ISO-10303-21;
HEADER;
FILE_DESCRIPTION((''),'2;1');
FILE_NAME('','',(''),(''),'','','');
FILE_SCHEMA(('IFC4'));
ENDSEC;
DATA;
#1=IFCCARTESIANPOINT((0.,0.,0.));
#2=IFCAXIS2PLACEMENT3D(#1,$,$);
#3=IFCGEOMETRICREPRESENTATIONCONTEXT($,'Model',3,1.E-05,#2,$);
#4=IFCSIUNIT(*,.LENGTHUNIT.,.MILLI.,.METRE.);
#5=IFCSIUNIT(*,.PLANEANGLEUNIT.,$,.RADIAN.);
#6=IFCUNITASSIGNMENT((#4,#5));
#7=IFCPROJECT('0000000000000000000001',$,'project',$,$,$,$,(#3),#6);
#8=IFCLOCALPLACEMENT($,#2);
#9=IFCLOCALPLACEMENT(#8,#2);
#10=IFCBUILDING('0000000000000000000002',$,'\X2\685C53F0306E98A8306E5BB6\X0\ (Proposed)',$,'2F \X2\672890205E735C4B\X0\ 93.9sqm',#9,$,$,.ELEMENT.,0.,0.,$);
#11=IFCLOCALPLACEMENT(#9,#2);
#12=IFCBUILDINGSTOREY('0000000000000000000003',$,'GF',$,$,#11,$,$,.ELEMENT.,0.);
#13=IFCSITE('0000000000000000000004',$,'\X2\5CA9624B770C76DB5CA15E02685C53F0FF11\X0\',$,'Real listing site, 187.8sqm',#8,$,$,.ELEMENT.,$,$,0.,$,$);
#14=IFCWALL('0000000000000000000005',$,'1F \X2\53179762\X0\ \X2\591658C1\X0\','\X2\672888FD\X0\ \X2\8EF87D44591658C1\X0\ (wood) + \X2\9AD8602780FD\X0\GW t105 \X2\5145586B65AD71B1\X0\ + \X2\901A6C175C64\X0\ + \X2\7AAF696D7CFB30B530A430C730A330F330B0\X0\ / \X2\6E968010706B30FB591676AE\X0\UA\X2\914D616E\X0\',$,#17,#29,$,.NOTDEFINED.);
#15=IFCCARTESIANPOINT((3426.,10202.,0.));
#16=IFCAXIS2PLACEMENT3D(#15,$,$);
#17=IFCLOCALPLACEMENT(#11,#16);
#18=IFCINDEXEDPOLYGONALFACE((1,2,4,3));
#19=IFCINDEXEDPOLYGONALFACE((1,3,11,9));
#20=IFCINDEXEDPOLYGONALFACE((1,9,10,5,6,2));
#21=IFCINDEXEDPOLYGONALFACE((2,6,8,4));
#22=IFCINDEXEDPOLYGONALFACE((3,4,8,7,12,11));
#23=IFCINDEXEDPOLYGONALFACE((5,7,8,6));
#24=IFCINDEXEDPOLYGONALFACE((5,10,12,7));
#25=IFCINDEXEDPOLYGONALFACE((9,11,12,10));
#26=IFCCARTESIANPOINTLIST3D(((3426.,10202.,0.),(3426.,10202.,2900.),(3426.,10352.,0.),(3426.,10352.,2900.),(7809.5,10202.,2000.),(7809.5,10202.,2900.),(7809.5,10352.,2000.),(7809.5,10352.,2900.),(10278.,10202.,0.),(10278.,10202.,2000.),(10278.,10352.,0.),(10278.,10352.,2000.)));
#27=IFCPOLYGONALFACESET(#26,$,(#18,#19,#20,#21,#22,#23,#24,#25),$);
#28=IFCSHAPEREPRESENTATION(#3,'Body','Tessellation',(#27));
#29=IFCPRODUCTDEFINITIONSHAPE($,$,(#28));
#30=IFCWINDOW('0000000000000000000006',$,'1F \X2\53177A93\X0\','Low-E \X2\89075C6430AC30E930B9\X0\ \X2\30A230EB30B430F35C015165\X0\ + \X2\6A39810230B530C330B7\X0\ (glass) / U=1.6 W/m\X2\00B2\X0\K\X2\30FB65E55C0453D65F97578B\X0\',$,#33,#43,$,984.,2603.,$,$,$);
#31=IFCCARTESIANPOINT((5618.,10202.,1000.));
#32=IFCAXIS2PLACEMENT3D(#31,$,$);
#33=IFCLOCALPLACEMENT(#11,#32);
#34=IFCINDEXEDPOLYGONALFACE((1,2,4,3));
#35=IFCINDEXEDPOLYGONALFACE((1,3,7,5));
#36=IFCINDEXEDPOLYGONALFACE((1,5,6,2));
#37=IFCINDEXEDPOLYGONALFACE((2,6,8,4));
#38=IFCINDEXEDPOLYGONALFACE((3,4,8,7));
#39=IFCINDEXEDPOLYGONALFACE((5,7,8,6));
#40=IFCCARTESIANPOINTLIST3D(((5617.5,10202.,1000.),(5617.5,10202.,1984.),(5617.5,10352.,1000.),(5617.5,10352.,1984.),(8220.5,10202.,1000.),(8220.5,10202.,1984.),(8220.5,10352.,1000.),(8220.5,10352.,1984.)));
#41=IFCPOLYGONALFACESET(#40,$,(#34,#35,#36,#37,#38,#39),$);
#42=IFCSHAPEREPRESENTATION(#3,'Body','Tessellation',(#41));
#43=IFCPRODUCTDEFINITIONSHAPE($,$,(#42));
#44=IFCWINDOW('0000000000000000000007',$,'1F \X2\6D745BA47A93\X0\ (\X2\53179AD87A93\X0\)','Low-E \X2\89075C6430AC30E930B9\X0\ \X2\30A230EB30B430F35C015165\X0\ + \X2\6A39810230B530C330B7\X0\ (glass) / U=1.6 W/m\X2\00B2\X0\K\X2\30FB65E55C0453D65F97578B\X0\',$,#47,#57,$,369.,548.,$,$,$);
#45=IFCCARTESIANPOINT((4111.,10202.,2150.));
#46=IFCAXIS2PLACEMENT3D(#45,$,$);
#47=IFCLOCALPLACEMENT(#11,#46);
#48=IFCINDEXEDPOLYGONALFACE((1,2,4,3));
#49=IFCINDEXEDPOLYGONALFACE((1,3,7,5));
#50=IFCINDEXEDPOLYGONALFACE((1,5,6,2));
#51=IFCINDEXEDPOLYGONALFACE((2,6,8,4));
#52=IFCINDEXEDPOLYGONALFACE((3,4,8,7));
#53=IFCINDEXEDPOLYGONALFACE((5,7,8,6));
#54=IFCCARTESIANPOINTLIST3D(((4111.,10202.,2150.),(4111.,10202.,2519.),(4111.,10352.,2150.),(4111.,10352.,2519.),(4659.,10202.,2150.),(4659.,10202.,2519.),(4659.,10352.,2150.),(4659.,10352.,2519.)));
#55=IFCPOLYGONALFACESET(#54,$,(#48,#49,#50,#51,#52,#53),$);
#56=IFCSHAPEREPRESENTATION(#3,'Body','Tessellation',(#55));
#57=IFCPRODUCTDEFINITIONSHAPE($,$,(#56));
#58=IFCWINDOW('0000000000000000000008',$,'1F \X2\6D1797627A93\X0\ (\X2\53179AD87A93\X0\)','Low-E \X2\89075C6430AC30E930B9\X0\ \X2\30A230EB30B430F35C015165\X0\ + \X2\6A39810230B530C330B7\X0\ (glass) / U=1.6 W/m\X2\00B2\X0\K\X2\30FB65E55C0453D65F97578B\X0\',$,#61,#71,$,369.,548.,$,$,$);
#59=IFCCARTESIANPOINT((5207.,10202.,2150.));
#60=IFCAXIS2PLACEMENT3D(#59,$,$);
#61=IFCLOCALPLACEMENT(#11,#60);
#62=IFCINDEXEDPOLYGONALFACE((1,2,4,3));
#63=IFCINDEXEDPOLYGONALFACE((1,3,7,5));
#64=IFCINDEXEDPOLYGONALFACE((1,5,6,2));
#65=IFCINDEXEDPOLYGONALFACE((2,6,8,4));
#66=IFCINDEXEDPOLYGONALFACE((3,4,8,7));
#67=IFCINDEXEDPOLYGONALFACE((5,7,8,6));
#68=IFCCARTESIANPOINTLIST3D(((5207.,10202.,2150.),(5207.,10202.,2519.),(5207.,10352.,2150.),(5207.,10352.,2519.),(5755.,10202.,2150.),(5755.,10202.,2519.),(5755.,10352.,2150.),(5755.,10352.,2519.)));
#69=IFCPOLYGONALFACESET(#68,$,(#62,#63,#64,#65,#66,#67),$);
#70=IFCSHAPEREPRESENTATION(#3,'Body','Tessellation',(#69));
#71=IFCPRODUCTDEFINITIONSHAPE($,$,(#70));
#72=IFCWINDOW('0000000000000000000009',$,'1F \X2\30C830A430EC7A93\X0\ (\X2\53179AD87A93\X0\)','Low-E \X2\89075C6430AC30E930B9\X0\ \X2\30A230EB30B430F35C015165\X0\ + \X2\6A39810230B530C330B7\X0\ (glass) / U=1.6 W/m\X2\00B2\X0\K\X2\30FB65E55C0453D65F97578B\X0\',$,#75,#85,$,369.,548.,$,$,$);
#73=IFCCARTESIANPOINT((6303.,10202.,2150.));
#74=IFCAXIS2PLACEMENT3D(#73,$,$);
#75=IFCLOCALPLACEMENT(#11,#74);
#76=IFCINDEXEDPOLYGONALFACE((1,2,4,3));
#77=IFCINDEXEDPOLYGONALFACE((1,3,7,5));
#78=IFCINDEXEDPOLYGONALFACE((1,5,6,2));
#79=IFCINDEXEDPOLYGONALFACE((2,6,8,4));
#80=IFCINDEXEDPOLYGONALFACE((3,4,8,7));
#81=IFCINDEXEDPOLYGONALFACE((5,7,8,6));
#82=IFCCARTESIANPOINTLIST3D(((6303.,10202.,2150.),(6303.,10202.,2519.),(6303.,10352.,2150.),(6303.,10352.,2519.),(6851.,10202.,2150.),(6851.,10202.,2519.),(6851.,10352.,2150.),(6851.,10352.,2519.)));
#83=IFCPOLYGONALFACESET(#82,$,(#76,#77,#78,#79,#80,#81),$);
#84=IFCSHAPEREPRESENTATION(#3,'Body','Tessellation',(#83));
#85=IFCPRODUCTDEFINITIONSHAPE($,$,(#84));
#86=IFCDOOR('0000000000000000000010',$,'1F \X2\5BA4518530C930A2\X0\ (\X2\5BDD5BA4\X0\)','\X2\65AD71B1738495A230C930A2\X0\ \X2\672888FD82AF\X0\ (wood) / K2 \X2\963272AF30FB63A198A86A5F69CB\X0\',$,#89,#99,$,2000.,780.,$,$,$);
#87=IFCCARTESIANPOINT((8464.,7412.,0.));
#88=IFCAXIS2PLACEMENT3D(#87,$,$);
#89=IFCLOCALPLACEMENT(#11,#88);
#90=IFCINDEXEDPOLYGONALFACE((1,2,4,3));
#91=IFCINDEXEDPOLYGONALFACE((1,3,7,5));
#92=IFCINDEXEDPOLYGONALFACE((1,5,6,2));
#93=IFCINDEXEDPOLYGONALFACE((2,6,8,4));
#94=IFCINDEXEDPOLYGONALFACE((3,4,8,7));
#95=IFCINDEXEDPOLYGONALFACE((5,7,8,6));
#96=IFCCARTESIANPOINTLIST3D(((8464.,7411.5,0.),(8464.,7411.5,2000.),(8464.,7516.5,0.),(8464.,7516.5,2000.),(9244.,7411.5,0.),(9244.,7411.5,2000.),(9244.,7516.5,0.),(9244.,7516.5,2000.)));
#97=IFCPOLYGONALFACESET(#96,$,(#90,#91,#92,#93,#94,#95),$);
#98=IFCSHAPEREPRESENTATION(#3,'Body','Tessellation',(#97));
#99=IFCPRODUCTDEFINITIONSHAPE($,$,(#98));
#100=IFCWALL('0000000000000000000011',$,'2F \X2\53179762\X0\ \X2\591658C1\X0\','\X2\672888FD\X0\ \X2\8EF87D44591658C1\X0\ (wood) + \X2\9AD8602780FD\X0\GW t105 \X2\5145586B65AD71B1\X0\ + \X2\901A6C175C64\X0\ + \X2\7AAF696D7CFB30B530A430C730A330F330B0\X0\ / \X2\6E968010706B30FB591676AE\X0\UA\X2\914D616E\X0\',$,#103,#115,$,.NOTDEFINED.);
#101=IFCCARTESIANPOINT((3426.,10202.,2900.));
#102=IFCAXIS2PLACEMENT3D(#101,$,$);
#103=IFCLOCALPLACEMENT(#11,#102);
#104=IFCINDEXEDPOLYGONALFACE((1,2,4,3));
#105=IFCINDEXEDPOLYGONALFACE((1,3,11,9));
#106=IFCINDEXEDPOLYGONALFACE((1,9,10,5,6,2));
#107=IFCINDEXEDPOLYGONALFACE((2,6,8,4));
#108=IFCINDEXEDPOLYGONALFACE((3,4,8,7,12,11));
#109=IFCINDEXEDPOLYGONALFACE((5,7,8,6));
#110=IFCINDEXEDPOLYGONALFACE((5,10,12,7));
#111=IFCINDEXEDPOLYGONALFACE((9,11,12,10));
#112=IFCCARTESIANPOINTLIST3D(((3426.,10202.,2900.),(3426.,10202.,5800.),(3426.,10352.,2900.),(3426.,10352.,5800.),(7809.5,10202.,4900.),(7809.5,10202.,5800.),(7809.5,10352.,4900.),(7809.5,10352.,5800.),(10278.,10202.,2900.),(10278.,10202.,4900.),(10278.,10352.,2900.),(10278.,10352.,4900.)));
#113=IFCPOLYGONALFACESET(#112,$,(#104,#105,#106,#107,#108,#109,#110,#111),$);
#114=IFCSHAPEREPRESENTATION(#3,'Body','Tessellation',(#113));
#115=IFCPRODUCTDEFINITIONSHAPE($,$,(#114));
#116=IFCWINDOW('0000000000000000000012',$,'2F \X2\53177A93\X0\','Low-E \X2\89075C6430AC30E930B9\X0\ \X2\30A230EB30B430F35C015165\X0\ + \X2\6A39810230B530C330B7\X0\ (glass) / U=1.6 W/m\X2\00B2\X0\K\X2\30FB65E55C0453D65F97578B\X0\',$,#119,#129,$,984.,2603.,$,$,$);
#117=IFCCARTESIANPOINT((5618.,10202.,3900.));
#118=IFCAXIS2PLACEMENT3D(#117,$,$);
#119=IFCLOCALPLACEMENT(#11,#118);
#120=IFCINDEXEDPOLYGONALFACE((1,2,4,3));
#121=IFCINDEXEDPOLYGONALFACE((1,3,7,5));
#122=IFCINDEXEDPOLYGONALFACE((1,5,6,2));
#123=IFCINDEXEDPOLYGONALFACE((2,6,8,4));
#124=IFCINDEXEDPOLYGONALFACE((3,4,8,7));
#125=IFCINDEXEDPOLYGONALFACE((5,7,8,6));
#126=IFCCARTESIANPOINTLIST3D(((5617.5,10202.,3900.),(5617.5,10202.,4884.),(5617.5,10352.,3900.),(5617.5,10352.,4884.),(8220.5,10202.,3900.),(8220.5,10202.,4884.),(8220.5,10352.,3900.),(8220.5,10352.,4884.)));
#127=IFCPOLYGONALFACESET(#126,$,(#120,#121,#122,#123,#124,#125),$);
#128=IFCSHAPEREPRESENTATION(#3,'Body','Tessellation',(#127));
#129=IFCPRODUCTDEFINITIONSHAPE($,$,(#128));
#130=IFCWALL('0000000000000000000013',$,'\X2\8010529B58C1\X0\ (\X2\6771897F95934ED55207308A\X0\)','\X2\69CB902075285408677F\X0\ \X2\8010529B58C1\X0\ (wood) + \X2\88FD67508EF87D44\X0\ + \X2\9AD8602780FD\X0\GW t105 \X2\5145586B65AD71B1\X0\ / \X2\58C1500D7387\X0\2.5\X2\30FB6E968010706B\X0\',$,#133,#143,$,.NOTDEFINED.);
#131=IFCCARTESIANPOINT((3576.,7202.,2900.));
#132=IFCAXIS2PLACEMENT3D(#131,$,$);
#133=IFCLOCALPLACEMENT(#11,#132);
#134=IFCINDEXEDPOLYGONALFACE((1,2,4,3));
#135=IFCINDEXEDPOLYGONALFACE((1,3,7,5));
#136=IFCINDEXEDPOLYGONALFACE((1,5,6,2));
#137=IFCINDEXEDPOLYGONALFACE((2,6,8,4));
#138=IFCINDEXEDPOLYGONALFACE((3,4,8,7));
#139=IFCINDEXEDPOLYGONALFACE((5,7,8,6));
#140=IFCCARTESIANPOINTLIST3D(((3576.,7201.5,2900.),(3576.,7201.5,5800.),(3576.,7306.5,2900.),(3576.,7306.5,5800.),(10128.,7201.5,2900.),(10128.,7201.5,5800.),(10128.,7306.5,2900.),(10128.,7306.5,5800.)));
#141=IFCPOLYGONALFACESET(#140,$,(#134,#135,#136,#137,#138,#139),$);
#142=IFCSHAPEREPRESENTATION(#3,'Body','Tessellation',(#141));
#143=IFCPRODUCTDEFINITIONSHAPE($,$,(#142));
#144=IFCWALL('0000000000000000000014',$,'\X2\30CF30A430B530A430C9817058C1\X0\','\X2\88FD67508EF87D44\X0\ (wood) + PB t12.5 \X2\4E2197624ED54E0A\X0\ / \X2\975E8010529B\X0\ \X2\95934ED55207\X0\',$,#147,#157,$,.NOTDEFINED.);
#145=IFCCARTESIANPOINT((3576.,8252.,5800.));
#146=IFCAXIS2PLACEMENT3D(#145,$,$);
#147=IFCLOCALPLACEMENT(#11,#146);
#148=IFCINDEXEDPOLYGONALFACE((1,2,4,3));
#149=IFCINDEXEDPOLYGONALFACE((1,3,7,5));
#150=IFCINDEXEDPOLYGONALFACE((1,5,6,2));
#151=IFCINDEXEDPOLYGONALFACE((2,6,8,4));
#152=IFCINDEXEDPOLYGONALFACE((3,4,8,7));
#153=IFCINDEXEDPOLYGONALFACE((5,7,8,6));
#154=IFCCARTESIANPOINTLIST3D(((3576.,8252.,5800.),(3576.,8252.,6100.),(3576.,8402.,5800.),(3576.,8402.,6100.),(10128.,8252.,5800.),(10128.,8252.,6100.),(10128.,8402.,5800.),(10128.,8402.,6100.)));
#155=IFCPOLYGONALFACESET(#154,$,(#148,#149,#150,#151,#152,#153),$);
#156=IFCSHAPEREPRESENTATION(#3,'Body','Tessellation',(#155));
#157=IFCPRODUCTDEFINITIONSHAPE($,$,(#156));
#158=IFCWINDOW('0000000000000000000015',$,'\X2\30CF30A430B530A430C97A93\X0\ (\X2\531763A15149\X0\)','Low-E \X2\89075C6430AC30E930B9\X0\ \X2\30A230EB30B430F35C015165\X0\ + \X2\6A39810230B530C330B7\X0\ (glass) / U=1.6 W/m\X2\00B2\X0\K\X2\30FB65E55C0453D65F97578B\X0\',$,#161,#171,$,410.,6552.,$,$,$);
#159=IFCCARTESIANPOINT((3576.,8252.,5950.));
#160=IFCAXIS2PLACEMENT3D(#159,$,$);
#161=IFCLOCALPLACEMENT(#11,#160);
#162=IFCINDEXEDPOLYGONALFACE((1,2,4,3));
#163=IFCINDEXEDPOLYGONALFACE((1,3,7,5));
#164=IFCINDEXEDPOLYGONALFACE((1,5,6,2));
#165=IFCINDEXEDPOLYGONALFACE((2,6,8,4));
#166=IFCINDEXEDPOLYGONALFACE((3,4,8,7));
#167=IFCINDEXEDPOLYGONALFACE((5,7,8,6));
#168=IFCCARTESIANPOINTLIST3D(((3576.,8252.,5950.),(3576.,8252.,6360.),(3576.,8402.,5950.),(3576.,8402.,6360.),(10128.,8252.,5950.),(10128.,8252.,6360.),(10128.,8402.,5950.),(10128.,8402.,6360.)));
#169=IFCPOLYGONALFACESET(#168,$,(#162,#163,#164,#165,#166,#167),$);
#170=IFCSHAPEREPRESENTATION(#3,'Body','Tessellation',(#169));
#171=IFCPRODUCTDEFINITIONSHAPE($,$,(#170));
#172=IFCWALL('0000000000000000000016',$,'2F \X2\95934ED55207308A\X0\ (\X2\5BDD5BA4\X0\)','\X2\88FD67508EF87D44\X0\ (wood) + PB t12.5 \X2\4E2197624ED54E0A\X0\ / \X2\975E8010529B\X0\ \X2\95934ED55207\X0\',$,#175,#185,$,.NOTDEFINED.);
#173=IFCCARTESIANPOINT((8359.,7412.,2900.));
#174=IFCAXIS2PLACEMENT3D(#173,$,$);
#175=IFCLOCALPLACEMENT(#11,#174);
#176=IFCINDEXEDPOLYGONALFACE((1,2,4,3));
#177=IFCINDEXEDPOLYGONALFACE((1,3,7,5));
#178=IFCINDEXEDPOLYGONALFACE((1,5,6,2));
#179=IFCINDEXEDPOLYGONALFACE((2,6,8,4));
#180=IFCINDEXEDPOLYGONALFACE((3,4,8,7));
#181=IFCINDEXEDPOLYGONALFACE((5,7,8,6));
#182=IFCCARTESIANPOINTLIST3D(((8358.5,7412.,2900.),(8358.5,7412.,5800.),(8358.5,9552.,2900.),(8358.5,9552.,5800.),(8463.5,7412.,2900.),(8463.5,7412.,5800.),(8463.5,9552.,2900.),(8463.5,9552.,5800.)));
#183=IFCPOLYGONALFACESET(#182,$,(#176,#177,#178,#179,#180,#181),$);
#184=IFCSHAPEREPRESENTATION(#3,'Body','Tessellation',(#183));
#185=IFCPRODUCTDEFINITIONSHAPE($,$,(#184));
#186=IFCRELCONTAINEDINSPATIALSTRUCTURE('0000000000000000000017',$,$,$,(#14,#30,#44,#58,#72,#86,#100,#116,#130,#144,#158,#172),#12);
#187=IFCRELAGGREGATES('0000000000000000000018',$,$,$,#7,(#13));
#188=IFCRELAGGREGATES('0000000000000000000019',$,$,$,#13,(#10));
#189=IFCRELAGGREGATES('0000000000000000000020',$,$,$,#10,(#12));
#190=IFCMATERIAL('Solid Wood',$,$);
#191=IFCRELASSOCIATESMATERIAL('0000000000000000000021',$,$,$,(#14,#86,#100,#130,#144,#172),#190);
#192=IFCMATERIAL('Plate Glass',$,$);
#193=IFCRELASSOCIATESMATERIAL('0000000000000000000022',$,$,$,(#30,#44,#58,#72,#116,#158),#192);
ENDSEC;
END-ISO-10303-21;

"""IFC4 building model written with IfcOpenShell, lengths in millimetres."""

from ifc_helpers import new_model, si_unit, frame, frame_2d, origin, place, context, project, spatial, rectangle, extrude, material, element, fill, save


model = new_model("IFC4")

# Units and contexts
model_context = context("Model", 3, precision=1e-05, world=origin())
ifc_project = project(units=[si_unit("LENGTHUNIT", "METRE", prefix="MILLI"), si_unit("PLANEANGLEUNIT", "RADIAN")], contexts=[model_context])

# Site, building, storey
site_placement = place(None, origin())
site = spatial("IfcSite", under=ifc_project, at=site_placement, Name="岩手県盛岡市桜台１", ObjectType="Real listing site, 187.8sqm", CompositionType="ELEMENT", RefElevation=0.0)
building_placement = place(site_placement, origin())
building = spatial("IfcBuilding", under=site, at=building_placement, Name="桜台の風の家 (Proposed)", ObjectType="2F 木造平屋 93.9sqm", CompositionType="ELEMENT", ElevationOfRefHeight=0.0, ElevationOfTerrain=0.0)
storey_placement = place(building_placement, origin())
storey = spatial("IfcBuildingStorey", under=building, at=storey_placement, Name="GF", CompositionType="ELEMENT", Elevation=0.0)

# Wall, openings, windows
ifc_material_1 = material(Name="Solid Wood")
wall_1_placement = place(storey_placement, frame((3426.0, 10202.0, 0.0)))
wall_1 = element("IfcWall", 1, at=wall_1_placement, inside=storey, material=ifc_material_1, Name="1F 北面 外壁", Description="木製 軸組外壁 (wood) + 高性能GW t105 充填断熱 + 通気層 + 窯業系サイディング / 準耐火・外皮UA配慮", PredefinedType="NOTDEFINED", context=model_context, shape_type="SweptSolid", body=[
    extrude(rectangle(XDim=6852.0, YDim=150.0, at=frame_2d((3426.0, 75.0))), frame((3426.0, 10202.0, 0.0)), (0.0, 0.0, 1.0), 2900.0),
])
opening_1_placement = place(storey_placement, frame((5618.0, 10202.0, 1000.0)))
opening_1 = element("IfcOpeningElement", 2, at=opening_1_placement, cuts=wall_1, PredefinedType="NOTDEFINED", context=model_context, shape_type="SweptSolid", body=[
    extrude(rectangle(XDim=2603.0, YDim=150.0, at=frame_2d((1301.0, 75.0))), frame((5618.0, 10202.0, 1000.0)), (0.0, 0.0, 1.0), 984.0),
])
opening_2_placement = place(storey_placement, frame((4111.0, 10202.0, 2150.0)))
opening_2 = element("IfcOpeningElement", 3, at=opening_2_placement, cuts=wall_1, PredefinedType="NOTDEFINED", context=model_context, shape_type="SweptSolid", body=[
    extrude(rectangle(XDim=548.0, YDim=150.0, at=frame_2d((274.0, 75.0))), frame((4111.0, 10202.0, 2150.0)), (0.0, 0.0, 1.0), 369.0),
])
opening_3_placement = place(storey_placement, frame((5207.0, 10202.0, 2150.0)))
opening_3 = element("IfcOpeningElement", 4, at=opening_3_placement, cuts=wall_1, PredefinedType="NOTDEFINED", context=model_context, shape_type="SweptSolid", body=[
    extrude(rectangle(XDim=548.0, YDim=150.0, at=frame_2d((274.0, 75.0))), frame((5207.0, 10202.0, 2150.0)), (0.0, 0.0, 1.0), 369.0),
])
opening_4_placement = place(storey_placement, frame((6303.0, 10202.0, 2150.0)))
opening_4 = element("IfcOpeningElement", 5, at=opening_4_placement, cuts=wall_1, PredefinedType="NOTDEFINED", context=model_context, shape_type="SweptSolid", body=[
    extrude(rectangle(XDim=548.0, YDim=150.0, at=frame_2d((274.0, 75.0))), frame((6303.0, 10202.0, 2150.0)), (0.0, 0.0, 1.0), 369.0),
])
ifc_material_2 = material(Name="Plate Glass")
window_1_placement = place(storey_placement, frame((5618.0, 10202.0, 1000.0)))
window_1 = element("IfcWindow", 6, at=window_1_placement, inside=storey, material=ifc_material_2, Name="1F 北窓", Description="Low-E 複層ガラス アルゴン封入 + 樹脂サッシ (glass) / U=1.6 W/m²K・日射取得型", OverallHeight=984.0, OverallWidth=2603.0, context=model_context, shape_type="SweptSolid", body=[
    extrude(rectangle(XDim=2603.0, YDim=150.0, at=frame_2d((1301.0, 75.0))), frame((5618.0, 10202.0, 1000.0)), (0.0, 0.0, 1.0), 984.0),
])
fill(opening_1, window_1)
window_2_placement = place(storey_placement, frame((4111.0, 10202.0, 2150.0)))
window_2 = element("IfcWindow", 7, at=window_2_placement, inside=storey, material=ifc_material_2, Name="1F 浴室窓 (北高窓)", Description="Low-E 複層ガラス アルゴン封入 + 樹脂サッシ (glass) / U=1.6 W/m²K・日射取得型", OverallHeight=369.0, OverallWidth=548.0, context=model_context, shape_type="SweptSolid", body=[
    extrude(rectangle(XDim=548.0, YDim=150.0, at=frame_2d((274.0, 75.0))), frame((4111.0, 10202.0, 2150.0)), (0.0, 0.0, 1.0), 369.0),
])
fill(opening_2, window_2)
window_3_placement = place(storey_placement, frame((5207.0, 10202.0, 2150.0)))
window_3 = element("IfcWindow", 8, at=window_3_placement, inside=storey, material=ifc_material_2, Name="1F 洗面窓 (北高窓)", Description="Low-E 複層ガラス アルゴン封入 + 樹脂サッシ (glass) / U=1.6 W/m²K・日射取得型", OverallHeight=369.0, OverallWidth=548.0, context=model_context, shape_type="SweptSolid", body=[
    extrude(rectangle(XDim=548.0, YDim=150.0, at=frame_2d((274.0, 75.0))), frame((5207.0, 10202.0, 2150.0)), (0.0, 0.0, 1.0), 369.0),
])
fill(opening_3, window_3)
window_4_placement = place(storey_placement, frame((6303.0, 10202.0, 2150.0)))
window_4 = element("IfcWindow", 9, at=window_4_placement, inside=storey, material=ifc_material_2, Name="1F トイレ窓 (北高窓)", Description="Low-E 複層ガラス アルゴン封入 + 樹脂サッシ (glass) / U=1.6 W/m²K・日射取得型", OverallHeight=369.0, OverallWidth=548.0, context=model_context, shape_type="SweptSolid", body=[
    extrude(rectangle(XDim=548.0, YDim=150.0, at=frame_2d((274.0, 75.0))), frame((6303.0, 10202.0, 2150.0)), (0.0, 0.0, 1.0), 369.0),
])
fill(opening_4, window_4)

# Door
door_1_placement = place(storey_placement, frame((8464.0, 7412.0, 0.0)))
element("IfcDoor", 10, at=door_1_placement, inside=storey, material=ifc_material_1, Name="1F 室内ドア (寝室)", Description="断熱玄関ドア 木製芯 (wood) / K2 防犯・採風機構", OverallHeight=2000.0, OverallWidth=780.0, context=model_context, shape_type="SweptSolid", body=[
    extrude(rectangle(XDim=780.0, YDim=105.0, at=frame_2d((390.0, 52.0))), frame((8464.0, 7412.0, 0.0)), (0.0, 0.0, 1.0), 2000.0),
])

# Wall, opening, window
wall_2_placement = place(storey_placement, frame((3426.0, 10202.0, 2900.0)))
wall_2 = element("IfcWall", 11, at=wall_2_placement, inside=storey, material=ifc_material_1, Name="2F 北面 外壁", Description="木製 軸組外壁 (wood) + 高性能GW t105 充填断熱 + 通気層 + 窯業系サイディング / 準耐火・外皮UA配慮", PredefinedType="NOTDEFINED", context=model_context, shape_type="SweptSolid", body=[
    extrude(rectangle(XDim=6852.0, YDim=150.0, at=frame_2d((3426.0, 75.0))), frame((3426.0, 10202.0, 2900.0)), (0.0, 0.0, 1.0), 2900.0),
])
opening_5_placement = place(storey_placement, frame((5618.0, 10202.0, 3900.0)))
opening_5 = element("IfcOpeningElement", 12, at=opening_5_placement, cuts=wall_2, PredefinedType="NOTDEFINED", context=model_context, shape_type="SweptSolid", body=[
    extrude(rectangle(XDim=2603.0, YDim=150.0, at=frame_2d((1301.0, 75.0))), frame((5618.0, 10202.0, 3900.0)), (0.0, 0.0, 1.0), 984.0),
])
window_5_placement = place(storey_placement, frame((5618.0, 10202.0, 3900.0)))
window_5 = element("IfcWindow", 13, at=window_5_placement, inside=storey, material=ifc_material_2, Name="2F 北窓", Description="Low-E 複層ガラス アルゴン封入 + 樹脂サッシ (glass) / U=1.6 W/m²K・日射取得型", OverallHeight=984.0, OverallWidth=2603.0, context=model_context, shape_type="SweptSolid", body=[
    extrude(rectangle(XDim=2603.0, YDim=150.0, at=frame_2d((1301.0, 75.0))), frame((5618.0, 10202.0, 3900.0)), (0.0, 0.0, 1.0), 984.0),
])
fill(opening_5, window_5)

# Wall
wall_3_placement = place(storey_placement, frame((3576.0, 7202.0, 2900.0)))
element("IfcWall", 14, at=wall_3_placement, inside=storey, material=ifc_material_1, Name="耐力壁 (東西間仕切り)", Description="構造用合板 耐力壁 (wood) + 製材軸組 + 高性能GW t105 充填断熱 / 壁倍率2.5・準耐火", PredefinedType="NOTDEFINED", context=model_context, shape_type="SweptSolid", body=[
    extrude(rectangle(XDim=6552.0, YDim=105.0, at=frame_2d((3276.0, 52.0))), frame((3576.0, 7202.0, 2900.0)), (0.0, 0.0, 1.0), 2900.0),
])

# Wall, opening, window
wall_4_placement = place(storey_placement, frame((3576.0, 8252.0, 5800.0)))
wall_4 = element("IfcWall", 15, at=wall_4_placement, inside=storey, material=ifc_material_1, Name="ハイサイド腰壁", Description="製材軸組 (wood) + PB t12.5 両面仕上 / 非耐力 間仕切", PredefinedType="NOTDEFINED", context=model_context, shape_type="SweptSolid", body=[
    extrude(rectangle(XDim=6552.0, YDim=150.0, at=frame_2d((3276.0, 75.0))), frame((3576.0, 8252.0, 5800.0)), (0.0, 0.0, 1.0), 700.0),
])
opening_6_placement = place(storey_placement, frame((3576.0, 8252.0, 5950.0)))
opening_6 = element("IfcOpeningElement", 16, at=opening_6_placement, cuts=wall_4, PredefinedType="NOTDEFINED", context=model_context, shape_type="SweptSolid", body=[
    extrude(rectangle(XDim=6552.0, YDim=150.0, at=frame_2d((3276.0, 75.0))), frame((3576.0, 8252.0, 5950.0)), (0.0, 0.0, 1.0), 410.0),
])
window_6_placement = place(storey_placement, frame((3576.0, 8252.0, 5950.0)))
window_6 = element("IfcWindow", 17, at=window_6_placement, inside=storey, material=ifc_material_2, Name="ハイサイド窓 (北採光)", Description="Low-E 複層ガラス アルゴン封入 + 樹脂サッシ (glass) / U=1.6 W/m²K・日射取得型", OverallHeight=410.0, OverallWidth=6552.0, context=model_context, shape_type="SweptSolid", body=[
    extrude(rectangle(XDim=6552.0, YDim=150.0, at=frame_2d((3276.0, 75.0))), frame((3576.0, 8252.0, 5950.0)), (0.0, 0.0, 1.0), 410.0),
])
fill(opening_6, window_6)

# Wall
wall_5_placement = place(storey_placement, frame((8359.0, 7412.0, 2900.0)))
element("IfcWall", 18, at=wall_5_placement, inside=storey, material=ifc_material_1, Name="2F 間仕切り (寝室)", Description="製材軸組 (wood) + PB t12.5 両面仕上 / 非耐力 間仕切", PredefinedType="NOTDEFINED", context=model_context, shape_type="SweptSolid", body=[
    extrude(rectangle(XDim=105.0, YDim=2140.0, at=frame_2d((52.0, 1070.0))), frame((8359.0, 7412.0, 2900.0)), (0.0, 0.0, 1.0), 2900.0),
])

save(model, "model.ifc")
